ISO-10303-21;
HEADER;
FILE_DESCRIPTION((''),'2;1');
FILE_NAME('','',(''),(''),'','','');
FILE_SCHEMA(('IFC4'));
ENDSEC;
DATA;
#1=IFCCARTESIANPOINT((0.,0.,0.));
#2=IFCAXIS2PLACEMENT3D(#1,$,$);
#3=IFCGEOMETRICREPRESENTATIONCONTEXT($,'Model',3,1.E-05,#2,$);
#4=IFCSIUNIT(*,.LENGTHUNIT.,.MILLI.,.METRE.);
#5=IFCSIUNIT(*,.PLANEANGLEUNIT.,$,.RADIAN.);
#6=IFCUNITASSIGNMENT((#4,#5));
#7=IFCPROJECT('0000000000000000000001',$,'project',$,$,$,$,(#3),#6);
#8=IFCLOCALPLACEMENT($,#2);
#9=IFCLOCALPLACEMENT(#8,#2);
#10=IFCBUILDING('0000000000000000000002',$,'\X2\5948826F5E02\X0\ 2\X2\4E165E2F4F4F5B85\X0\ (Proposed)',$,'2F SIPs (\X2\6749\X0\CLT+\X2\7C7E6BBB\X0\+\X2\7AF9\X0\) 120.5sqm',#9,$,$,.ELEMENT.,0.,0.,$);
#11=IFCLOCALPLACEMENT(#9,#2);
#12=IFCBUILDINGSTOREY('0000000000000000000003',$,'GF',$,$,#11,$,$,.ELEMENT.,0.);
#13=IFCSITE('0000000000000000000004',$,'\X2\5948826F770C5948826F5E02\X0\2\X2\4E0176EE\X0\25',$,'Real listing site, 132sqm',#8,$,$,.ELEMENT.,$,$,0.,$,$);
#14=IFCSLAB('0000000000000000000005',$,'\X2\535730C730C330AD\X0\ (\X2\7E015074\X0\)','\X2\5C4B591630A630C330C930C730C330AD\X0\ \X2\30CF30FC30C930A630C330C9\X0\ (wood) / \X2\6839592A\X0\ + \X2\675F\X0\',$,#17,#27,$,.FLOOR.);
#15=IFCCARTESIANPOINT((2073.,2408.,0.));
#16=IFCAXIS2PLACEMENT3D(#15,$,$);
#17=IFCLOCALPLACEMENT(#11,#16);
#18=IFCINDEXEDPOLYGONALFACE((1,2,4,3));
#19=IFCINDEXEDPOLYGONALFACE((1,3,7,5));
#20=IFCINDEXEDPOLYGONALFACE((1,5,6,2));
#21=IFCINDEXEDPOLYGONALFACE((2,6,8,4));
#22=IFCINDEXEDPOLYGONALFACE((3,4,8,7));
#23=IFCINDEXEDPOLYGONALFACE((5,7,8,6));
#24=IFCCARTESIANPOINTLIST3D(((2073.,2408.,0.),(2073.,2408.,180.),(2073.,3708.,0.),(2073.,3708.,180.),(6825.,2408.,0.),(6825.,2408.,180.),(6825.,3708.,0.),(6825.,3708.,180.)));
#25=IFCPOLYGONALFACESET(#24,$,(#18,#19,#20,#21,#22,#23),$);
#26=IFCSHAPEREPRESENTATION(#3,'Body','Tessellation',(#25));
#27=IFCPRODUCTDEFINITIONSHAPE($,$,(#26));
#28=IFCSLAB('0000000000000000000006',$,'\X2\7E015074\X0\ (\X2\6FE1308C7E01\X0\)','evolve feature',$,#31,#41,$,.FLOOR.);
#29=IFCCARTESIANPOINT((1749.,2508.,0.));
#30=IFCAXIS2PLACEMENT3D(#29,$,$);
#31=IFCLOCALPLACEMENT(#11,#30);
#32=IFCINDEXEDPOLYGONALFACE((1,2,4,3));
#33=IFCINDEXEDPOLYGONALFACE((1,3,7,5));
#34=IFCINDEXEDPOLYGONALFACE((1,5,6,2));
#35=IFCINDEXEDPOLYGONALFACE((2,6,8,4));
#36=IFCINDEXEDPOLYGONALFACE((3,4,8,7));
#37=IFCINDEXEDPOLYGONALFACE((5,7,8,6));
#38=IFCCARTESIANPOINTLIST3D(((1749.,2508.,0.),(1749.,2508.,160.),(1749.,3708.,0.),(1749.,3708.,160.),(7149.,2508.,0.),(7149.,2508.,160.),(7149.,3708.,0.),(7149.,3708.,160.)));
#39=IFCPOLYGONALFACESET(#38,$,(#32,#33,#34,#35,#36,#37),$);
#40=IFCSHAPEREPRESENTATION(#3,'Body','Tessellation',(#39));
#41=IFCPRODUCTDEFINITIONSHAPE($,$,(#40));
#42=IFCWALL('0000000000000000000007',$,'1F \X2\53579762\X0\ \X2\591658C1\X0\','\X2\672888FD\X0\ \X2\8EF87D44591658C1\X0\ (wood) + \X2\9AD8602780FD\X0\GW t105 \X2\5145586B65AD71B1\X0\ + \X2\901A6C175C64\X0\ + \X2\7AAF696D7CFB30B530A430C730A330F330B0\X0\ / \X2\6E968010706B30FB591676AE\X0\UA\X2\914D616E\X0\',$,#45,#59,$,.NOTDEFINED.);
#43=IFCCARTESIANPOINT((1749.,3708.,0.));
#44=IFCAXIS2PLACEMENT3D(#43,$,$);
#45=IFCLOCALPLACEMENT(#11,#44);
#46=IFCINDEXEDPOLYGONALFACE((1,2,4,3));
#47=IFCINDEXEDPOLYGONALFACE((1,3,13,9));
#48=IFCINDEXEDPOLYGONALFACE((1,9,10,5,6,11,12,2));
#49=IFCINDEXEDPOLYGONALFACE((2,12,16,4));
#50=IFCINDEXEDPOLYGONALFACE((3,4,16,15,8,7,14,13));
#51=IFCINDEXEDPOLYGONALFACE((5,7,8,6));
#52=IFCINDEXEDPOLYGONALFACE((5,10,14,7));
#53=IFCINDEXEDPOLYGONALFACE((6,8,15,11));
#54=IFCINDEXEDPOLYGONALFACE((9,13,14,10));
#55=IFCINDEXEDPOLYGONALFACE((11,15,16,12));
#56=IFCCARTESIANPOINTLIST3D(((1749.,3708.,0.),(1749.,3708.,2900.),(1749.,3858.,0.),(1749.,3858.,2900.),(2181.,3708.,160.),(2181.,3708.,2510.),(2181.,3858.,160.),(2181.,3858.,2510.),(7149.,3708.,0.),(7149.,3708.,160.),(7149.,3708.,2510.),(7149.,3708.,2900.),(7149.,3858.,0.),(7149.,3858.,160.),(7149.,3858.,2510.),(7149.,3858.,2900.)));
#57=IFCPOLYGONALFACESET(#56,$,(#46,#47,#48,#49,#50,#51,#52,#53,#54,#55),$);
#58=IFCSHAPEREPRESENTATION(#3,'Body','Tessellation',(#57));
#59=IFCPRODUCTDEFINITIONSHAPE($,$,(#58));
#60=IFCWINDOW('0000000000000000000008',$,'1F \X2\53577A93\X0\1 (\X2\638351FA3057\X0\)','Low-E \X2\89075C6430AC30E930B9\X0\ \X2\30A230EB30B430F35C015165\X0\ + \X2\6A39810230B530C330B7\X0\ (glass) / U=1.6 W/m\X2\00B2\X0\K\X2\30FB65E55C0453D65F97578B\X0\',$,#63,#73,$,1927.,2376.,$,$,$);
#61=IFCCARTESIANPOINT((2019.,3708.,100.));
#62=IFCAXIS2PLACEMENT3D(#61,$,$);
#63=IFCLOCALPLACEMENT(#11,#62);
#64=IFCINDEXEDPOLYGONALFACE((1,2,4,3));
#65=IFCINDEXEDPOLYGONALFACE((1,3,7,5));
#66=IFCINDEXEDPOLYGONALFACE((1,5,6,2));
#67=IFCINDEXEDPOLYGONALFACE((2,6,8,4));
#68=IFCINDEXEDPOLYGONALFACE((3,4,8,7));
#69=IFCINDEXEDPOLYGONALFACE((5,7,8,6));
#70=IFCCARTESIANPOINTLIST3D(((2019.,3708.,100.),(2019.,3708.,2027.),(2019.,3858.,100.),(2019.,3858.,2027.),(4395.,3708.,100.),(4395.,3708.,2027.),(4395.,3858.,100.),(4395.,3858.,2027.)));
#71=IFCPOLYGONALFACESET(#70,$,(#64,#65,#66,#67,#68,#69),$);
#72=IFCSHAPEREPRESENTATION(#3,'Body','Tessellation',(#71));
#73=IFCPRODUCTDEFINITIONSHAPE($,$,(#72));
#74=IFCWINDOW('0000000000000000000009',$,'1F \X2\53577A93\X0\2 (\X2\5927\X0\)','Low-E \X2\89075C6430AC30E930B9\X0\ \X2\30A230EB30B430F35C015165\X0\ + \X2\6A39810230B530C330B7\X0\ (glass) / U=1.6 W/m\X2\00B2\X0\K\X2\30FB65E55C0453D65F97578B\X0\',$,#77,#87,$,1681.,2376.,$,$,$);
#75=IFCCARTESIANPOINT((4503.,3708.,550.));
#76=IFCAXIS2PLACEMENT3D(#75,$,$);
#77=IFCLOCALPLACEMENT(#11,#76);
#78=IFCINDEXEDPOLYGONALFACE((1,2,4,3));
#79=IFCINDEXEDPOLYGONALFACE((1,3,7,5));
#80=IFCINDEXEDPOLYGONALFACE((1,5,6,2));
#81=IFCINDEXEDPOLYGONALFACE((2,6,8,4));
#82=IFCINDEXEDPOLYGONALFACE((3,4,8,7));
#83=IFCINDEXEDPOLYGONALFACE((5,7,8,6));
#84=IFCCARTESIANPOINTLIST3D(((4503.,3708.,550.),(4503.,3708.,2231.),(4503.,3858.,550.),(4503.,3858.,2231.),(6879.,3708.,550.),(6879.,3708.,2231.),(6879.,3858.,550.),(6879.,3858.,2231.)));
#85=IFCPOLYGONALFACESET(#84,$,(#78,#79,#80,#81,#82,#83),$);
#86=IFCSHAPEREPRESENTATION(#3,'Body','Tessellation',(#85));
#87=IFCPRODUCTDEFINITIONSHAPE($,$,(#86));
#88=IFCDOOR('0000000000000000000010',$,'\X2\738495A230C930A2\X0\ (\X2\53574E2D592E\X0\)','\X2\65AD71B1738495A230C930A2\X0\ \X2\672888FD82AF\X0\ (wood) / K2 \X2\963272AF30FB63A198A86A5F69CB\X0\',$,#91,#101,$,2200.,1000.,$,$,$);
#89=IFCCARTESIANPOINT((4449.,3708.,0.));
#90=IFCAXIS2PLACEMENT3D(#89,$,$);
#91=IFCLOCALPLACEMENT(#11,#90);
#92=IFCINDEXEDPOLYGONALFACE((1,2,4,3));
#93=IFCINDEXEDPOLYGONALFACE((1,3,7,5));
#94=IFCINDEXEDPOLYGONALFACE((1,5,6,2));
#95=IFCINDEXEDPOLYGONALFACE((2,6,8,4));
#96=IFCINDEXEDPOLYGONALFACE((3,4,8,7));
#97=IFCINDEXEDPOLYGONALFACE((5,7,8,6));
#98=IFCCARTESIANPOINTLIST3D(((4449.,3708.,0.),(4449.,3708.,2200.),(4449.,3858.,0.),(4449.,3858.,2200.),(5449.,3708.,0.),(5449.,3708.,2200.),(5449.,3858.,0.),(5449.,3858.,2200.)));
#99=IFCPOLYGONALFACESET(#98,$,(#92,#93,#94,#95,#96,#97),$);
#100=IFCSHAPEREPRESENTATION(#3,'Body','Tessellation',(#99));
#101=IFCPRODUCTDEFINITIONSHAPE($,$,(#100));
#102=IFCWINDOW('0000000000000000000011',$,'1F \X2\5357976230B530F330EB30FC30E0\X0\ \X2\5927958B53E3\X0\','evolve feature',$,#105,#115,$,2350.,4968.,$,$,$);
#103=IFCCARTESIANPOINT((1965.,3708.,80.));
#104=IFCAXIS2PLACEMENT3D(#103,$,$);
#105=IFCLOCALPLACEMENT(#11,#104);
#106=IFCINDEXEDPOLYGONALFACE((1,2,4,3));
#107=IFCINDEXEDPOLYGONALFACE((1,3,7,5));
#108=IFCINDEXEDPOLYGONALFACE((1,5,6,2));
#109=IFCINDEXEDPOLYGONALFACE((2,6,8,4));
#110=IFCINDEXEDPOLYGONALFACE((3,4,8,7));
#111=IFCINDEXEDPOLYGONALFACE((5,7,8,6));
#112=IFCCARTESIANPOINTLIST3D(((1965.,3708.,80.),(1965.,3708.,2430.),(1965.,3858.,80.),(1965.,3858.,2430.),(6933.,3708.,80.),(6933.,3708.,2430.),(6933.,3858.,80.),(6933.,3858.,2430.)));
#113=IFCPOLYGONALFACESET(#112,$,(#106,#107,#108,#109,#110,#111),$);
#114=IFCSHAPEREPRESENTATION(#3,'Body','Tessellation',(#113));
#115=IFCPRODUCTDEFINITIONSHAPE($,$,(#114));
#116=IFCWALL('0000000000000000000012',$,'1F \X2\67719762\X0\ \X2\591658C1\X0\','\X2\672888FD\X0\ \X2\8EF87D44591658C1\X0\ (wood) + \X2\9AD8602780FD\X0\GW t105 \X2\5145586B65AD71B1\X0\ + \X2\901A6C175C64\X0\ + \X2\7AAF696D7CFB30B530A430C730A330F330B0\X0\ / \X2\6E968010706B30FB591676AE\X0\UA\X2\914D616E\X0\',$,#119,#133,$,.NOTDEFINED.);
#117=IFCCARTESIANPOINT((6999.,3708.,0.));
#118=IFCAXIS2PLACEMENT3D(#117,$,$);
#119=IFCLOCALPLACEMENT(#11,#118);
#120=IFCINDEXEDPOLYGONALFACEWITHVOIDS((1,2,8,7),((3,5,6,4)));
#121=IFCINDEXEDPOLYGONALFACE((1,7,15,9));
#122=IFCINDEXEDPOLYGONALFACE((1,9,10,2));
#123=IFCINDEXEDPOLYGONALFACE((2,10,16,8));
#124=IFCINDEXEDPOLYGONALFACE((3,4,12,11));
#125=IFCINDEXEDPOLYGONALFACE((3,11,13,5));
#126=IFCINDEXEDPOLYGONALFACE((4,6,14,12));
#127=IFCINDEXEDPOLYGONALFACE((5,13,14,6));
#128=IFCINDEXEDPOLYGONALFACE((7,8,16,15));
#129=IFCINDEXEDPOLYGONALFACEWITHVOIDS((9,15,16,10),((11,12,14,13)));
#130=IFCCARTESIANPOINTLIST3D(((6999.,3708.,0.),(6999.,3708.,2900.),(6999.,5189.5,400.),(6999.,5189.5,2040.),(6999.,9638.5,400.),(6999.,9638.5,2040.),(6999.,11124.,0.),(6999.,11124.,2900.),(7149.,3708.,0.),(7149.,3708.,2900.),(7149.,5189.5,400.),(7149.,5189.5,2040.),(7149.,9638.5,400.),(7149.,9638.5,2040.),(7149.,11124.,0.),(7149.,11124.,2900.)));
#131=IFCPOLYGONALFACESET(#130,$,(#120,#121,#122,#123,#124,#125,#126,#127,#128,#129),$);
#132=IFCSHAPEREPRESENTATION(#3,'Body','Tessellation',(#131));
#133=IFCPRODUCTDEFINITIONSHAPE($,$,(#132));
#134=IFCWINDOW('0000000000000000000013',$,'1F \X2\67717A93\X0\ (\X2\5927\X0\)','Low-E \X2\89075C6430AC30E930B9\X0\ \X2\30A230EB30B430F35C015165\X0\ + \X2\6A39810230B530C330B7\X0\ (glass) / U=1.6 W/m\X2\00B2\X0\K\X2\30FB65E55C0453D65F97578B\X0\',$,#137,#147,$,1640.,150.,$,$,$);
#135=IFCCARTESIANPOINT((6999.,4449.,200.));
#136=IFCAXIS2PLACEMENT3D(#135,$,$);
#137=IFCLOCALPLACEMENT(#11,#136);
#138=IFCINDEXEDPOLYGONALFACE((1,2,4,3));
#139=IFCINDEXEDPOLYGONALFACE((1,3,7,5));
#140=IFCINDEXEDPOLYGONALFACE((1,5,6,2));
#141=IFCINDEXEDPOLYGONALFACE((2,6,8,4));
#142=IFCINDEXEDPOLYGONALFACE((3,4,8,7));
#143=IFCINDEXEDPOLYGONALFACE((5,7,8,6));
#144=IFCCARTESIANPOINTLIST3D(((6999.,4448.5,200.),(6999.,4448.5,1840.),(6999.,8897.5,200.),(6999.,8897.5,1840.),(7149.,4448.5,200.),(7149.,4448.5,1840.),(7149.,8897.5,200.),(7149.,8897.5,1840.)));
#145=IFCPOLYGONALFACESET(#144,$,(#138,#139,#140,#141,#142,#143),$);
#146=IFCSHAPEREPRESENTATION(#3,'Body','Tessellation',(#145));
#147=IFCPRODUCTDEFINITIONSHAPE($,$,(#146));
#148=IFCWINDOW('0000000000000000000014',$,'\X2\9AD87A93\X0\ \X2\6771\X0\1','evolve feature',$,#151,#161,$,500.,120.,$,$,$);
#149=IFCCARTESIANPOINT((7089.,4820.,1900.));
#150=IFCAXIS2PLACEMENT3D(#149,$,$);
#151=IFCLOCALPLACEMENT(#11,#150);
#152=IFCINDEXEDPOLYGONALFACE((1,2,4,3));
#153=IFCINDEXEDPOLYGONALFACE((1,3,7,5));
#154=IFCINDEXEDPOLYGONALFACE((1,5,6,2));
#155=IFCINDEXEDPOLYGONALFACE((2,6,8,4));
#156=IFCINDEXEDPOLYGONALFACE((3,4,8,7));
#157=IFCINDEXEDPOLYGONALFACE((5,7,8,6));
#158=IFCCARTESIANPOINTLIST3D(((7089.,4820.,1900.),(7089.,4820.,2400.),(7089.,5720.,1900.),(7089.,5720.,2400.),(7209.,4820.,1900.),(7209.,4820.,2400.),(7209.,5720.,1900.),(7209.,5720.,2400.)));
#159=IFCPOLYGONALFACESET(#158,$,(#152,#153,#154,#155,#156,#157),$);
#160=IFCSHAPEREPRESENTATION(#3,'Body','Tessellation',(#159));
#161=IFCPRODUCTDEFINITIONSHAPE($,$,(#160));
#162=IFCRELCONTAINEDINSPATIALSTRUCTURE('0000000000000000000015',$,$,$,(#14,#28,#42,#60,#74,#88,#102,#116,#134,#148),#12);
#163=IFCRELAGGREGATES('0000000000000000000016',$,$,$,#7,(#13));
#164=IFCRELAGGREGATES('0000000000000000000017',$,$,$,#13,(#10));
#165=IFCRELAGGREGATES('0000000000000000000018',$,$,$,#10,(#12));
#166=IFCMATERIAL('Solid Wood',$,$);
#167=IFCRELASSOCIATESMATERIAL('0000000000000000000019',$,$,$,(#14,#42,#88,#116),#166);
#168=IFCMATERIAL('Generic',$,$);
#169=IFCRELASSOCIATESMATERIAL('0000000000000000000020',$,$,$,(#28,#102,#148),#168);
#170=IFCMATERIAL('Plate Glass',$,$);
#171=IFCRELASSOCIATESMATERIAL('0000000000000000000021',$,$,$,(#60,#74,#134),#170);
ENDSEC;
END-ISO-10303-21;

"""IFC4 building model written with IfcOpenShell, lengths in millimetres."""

from ifc_helpers import new_model, si_unit, frame, frame_2d, origin, place, context, project, spatial, rectangle, extrude, material, element, fill, save


model = new_model("IFC4")

# Units and contexts
model_context = context("Model", 3, precision=1e-05, world=origin())
ifc_project = project(units=[si_unit("LENGTHUNIT", "METRE", prefix="MILLI"), si_unit("PLANEANGLEUNIT", "RADIAN")], contexts=[model_context])

# Site, building, storey
site_placement = place(None, origin())
site = spatial("IfcSite", under=ifc_project, at=site_placement, Name="奈良県奈良市2丁目25", ObjectType="Real listing site, 132sqm", CompositionType="ELEMENT", RefElevation=0.0)
building_placement = place(site_placement, origin())
building = spatial("IfcBuilding", under=site, at=building_placement, Name="奈良市 2世帯住宅 (Proposed)", ObjectType="2F SIPs (杉CLT+籾殻+竹) 120.5sqm", CompositionType="ELEMENT", ElevationOfRefHeight=0.0, ElevationOfTerrain=0.0)
storey_placement = place(building_placement, origin())
storey = spatial("IfcBuildingStorey", under=building, at=storey_placement, Name="GF", CompositionType="ELEMENT", Elevation=0.0)

# Slabs
ifc_material_1 = material(Name="Solid Wood")
slab_1_placement = place(storey_placement, frame((2073.0, 2408.0, 0.0)))
element("IfcSlab", 1, at=slab_1_placement, inside=storey, material=ifc_material_1, Name="南デッキ (縁側)", Description="屋外ウッドデッキ ハードウッド (wood) / 根太 + 束", PredefinedType="FLOOR", context=model_context, shape_type="SweptSolid", body=[
    extrude(rectangle(XDim=4752.0, YDim=1300.0, at=frame_2d((2376.0, 650.0))), frame((2073.0, 2408.0, 0.0)), (0.0, 0.0, 1.0), 180.0),
])
ifc_material_2 = material(Name="Generic")
slab_2_placement = place(storey_placement, frame((1749.0, 2508.0, 0.0)))
element("IfcSlab", 2, at=slab_2_placement, inside=storey, material=ifc_material_2, Name="縁側 (濡れ縁)", Description="evolve feature", PredefinedType="FLOOR", context=model_context, shape_type="SweptSolid", body=[
    extrude(rectangle(XDim=5400.0, YDim=1200.0, at=frame_2d((2700.0, 600.0))), frame((1749.0, 2508.0, 0.0)), (0.0, 0.0, 1.0), 160.0),
])

# Wall, openings, windows, door
wall_1_placement = place(storey_placement, frame((1749.0, 3708.0, 0.0)))
wall_1 = element("IfcWall", 3, at=wall_1_placement, inside=storey, material=ifc_material_1, Name="1F 南面 外壁", Description="木製 軸組外壁 (wood) + 高性能GW t105 充填断熱 + 通気層 + 窯業系サイディング / 準耐火・外皮UA配慮", PredefinedType="NOTDEFINED", context=model_context, shape_type="SweptSolid", body=[
    extrude(rectangle(XDim=5400.0, YDim=150.0, at=frame_2d((2700.0, 75.0))), frame((1749.0, 3708.0, 0.0)), (0.0, 0.0, 1.0), 2900.0),
])
opening_1_placement = place(storey_placement, frame((2019.0, 3708.0, 100.0)))
opening_1 = element("IfcOpeningElement", 4, at=opening_1_placement, cuts=wall_1, PredefinedType="NOTDEFINED", context=model_context, shape_type="SweptSolid", body=[
    extrude(rectangle(XDim=2376.0, YDim=150.0, at=frame_2d((1188.0, 75.0))), frame((2019.0, 3708.0, 100.0)), (0.0, 0.0, 1.0), 1927.0),
])
opening_2_placement = place(storey_placement, frame((4503.0, 3708.0, 550.0)))
opening_2 = element("IfcOpeningElement", 5, at=opening_2_placement, cuts=wall_1, PredefinedType="NOTDEFINED", context=model_context, shape_type="SweptSolid", body=[
    extrude(rectangle(XDim=2376.0, YDim=150.0, at=frame_2d((1188.0, 75.0))), frame((4503.0, 3708.0, 550.0)), (0.0, 0.0, 1.0), 1681.0),
])
opening_3_placement = place(storey_placement, frame((4449.0, 3708.0, 0.0)))
opening_3 = element("IfcOpeningElement", 6, at=opening_3_placement, cuts=wall_1, PredefinedType="NOTDEFINED", context=model_context, shape_type="SweptSolid", body=[
    extrude(rectangle(XDim=1000.0, YDim=150.0, at=frame_2d((500.0, 75.0))), frame((4449.0, 3708.0, 0.0)), (0.0, 0.0, 1.0), 2200.0),
])
opening_4_placement = place(storey_placement, frame((1965.0, 3708.0, 80.0)))
opening_4 = element("IfcOpeningElement", 7, at=opening_4_placement, cuts=wall_1, PredefinedType="NOTDEFINED", context=model_context, shape_type="SweptSolid", body=[
    extrude(rectangle(XDim=4968.0, YDim=150.0, at=frame_2d((2484.0, 75.0))), frame((1965.0, 3708.0, 80.0)), (0.0, 0.0, 1.0), 2350.0),
])
ifc_material_3 = material(Name="Plate Glass")
window_1_placement = place(storey_placement, frame((2019.0, 3708.0, 100.0)))
window_1 = element("IfcWindow", 8, at=window_1_placement, inside=storey, material=ifc_material_3, Name="1F 南窓1 (掃出し)", Description="Low-E 複層ガラス アルゴン封入 + 樹脂サッシ (glass) / U=1.6 W/m²K・日射取得型", OverallHeight=1927.0, OverallWidth=2376.0, context=model_context, shape_type="SweptSolid", body=[
    extrude(rectangle(XDim=2376.0, YDim=150.0, at=frame_2d((1188.0, 75.0))), frame((2019.0, 3708.0, 100.0)), (0.0, 0.0, 1.0), 1927.0),
])
fill(opening_1, window_1)
window_2_placement = place(storey_placement, frame((4503.0, 3708.0, 550.0)))
window_2 = element("IfcWindow", 9, at=window_2_placement, inside=storey, material=ifc_material_3, Name="1F 南窓2 (大)", Description="Low-E 複層ガラス アルゴン封入 + 樹脂サッシ (glass) / U=1.6 W/m²K・日射取得型", OverallHeight=1681.0, OverallWidth=2376.0, context=model_context, shape_type="SweptSolid", body=[
    extrude(rectangle(XDim=2376.0, YDim=150.0, at=frame_2d((1188.0, 75.0))), frame((4503.0, 3708.0, 550.0)), (0.0, 0.0, 1.0), 1681.0),
])
fill(opening_2, window_2)
door_placement = place(storey_placement, frame((4449.0, 3708.0, 0.0)))
door = element("IfcDoor", 10, at=door_placement, inside=storey, material=ifc_material_1, Name="玄関ドア (南中央)", Description="断熱玄関ドア 木製芯 (wood) / K2 防犯・採風機構", OverallHeight=2200.0, OverallWidth=1000.0, context=model_context, shape_type="SweptSolid", body=[
    extrude(rectangle(XDim=1000.0, YDim=150.0, at=frame_2d((500.0, 75.0))), frame((4449.0, 3708.0, 0.0)), (0.0, 0.0, 1.0), 2200.0),
])
fill(opening_3, door)
window_3_placement = place(storey_placement, frame((1965.0, 3708.0, 80.0)))
window_3 = element("IfcWindow", 11, at=window_3_placement, inside=storey, material=ifc_material_2, Name="1F 南面サンルーム 大開口", Description="evolve feature", OverallHeight=2350.0, OverallWidth=4968.0, context=model_context, shape_type="SweptSolid", body=[
    extrude(rectangle(XDim=4968.0, YDim=150.0, at=frame_2d((2484.0, 75.0))), frame((1965.0, 3708.0, 80.0)), (0.0, 0.0, 1.0), 2350.0),
])
fill(opening_4, window_3)

# Wall, openings, windows
wall_2_placement = place(storey_placement, frame((6999.0, 3708.0, 0.0)))
wall_2 = element("IfcWall", 12, at=wall_2_placement, inside=storey, material=ifc_material_1, Name="1F 東面 外壁", Description="木製 軸組外壁 (wood) + 高性能GW t105 充填断熱 + 通気層 + 窯業系サイディング / 準耐火・外皮UA配慮", PredefinedType="NOTDEFINED", context=model_context, shape_type="SweptSolid", body=[
    extrude(rectangle(XDim=150.0, YDim=7416.0, at=frame_2d((75.0, 3708.0))), frame((6999.0, 3708.0, 0.0)), (0.0, 0.0, 1.0), 2900.0),
])
opening_5_placement = place(storey_placement, frame((6999.0, 4449.0, 200.0)))
opening_5 = element("IfcOpeningElement", 13, at=opening_5_placement, cuts=wall_2, PredefinedType="NOTDEFINED", context=model_context, shape_type="SweptSolid", body=[
    extrude(rectangle(XDim=150.0, YDim=4449.0, at=frame_2d((75.0, 2224.0))), frame((6999.0, 4449.0, 200.0)), (0.0, 0.0, 1.0), 1640.0),
])
opening_6_placement = place(storey_placement, frame((7089.0, 4820.0, 1900.0)))
opening_6 = element("IfcOpeningElement", 14, at=opening_6_placement, cuts=wall_2, PredefinedType="NOTDEFINED", context=model_context, shape_type="SweptSolid", body=[
    extrude(rectangle(XDim=120.0, YDim=900.0, at=frame_2d((60.0, 450.0))), frame((7089.0, 4820.0, 1900.0)), (0.0, 0.0, 1.0), 500.0),
])
window_4_placement = place(storey_placement, frame((6999.0, 4449.0, 200.0)))
window_4 = element("IfcWindow", 15, at=window_4_placement, inside=storey, material=ifc_material_3, Name="1F 東窓 (大)", Description="Low-E 複層ガラス アルゴン封入 + 樹脂サッシ (glass) / U=1.6 W/m²K・日射取得型", OverallHeight=1640.0, OverallWidth=150.0, context=model_context, shape_type="SweptSolid", body=[
    extrude(rectangle(XDim=150.0, YDim=4449.0, at=frame_2d((75.0, 2224.0))), frame((6999.0, 4449.0, 200.0)), (0.0, 0.0, 1.0), 1640.0),
])
fill(opening_5, window_4)
window_5_placement = place(storey_placement, frame((7089.0, 4820.0, 1900.0)))
window_5 = element("IfcWindow", 16, at=window_5_placement, inside=storey, material=ifc_material_2, Name="高窓 東1", Description="evolve feature", OverallHeight=500.0, OverallWidth=120.0, context=model_context, shape_type="SweptSolid", body=[
    extrude(rectangle(XDim=120.0, YDim=900.0, at=frame_2d((60.0, 450.0))), frame((7089.0, 4820.0, 1900.0)), (0.0, 0.0, 1.0), 500.0),
])
fill(opening_6, window_5)

save(model, "model.ifc")
